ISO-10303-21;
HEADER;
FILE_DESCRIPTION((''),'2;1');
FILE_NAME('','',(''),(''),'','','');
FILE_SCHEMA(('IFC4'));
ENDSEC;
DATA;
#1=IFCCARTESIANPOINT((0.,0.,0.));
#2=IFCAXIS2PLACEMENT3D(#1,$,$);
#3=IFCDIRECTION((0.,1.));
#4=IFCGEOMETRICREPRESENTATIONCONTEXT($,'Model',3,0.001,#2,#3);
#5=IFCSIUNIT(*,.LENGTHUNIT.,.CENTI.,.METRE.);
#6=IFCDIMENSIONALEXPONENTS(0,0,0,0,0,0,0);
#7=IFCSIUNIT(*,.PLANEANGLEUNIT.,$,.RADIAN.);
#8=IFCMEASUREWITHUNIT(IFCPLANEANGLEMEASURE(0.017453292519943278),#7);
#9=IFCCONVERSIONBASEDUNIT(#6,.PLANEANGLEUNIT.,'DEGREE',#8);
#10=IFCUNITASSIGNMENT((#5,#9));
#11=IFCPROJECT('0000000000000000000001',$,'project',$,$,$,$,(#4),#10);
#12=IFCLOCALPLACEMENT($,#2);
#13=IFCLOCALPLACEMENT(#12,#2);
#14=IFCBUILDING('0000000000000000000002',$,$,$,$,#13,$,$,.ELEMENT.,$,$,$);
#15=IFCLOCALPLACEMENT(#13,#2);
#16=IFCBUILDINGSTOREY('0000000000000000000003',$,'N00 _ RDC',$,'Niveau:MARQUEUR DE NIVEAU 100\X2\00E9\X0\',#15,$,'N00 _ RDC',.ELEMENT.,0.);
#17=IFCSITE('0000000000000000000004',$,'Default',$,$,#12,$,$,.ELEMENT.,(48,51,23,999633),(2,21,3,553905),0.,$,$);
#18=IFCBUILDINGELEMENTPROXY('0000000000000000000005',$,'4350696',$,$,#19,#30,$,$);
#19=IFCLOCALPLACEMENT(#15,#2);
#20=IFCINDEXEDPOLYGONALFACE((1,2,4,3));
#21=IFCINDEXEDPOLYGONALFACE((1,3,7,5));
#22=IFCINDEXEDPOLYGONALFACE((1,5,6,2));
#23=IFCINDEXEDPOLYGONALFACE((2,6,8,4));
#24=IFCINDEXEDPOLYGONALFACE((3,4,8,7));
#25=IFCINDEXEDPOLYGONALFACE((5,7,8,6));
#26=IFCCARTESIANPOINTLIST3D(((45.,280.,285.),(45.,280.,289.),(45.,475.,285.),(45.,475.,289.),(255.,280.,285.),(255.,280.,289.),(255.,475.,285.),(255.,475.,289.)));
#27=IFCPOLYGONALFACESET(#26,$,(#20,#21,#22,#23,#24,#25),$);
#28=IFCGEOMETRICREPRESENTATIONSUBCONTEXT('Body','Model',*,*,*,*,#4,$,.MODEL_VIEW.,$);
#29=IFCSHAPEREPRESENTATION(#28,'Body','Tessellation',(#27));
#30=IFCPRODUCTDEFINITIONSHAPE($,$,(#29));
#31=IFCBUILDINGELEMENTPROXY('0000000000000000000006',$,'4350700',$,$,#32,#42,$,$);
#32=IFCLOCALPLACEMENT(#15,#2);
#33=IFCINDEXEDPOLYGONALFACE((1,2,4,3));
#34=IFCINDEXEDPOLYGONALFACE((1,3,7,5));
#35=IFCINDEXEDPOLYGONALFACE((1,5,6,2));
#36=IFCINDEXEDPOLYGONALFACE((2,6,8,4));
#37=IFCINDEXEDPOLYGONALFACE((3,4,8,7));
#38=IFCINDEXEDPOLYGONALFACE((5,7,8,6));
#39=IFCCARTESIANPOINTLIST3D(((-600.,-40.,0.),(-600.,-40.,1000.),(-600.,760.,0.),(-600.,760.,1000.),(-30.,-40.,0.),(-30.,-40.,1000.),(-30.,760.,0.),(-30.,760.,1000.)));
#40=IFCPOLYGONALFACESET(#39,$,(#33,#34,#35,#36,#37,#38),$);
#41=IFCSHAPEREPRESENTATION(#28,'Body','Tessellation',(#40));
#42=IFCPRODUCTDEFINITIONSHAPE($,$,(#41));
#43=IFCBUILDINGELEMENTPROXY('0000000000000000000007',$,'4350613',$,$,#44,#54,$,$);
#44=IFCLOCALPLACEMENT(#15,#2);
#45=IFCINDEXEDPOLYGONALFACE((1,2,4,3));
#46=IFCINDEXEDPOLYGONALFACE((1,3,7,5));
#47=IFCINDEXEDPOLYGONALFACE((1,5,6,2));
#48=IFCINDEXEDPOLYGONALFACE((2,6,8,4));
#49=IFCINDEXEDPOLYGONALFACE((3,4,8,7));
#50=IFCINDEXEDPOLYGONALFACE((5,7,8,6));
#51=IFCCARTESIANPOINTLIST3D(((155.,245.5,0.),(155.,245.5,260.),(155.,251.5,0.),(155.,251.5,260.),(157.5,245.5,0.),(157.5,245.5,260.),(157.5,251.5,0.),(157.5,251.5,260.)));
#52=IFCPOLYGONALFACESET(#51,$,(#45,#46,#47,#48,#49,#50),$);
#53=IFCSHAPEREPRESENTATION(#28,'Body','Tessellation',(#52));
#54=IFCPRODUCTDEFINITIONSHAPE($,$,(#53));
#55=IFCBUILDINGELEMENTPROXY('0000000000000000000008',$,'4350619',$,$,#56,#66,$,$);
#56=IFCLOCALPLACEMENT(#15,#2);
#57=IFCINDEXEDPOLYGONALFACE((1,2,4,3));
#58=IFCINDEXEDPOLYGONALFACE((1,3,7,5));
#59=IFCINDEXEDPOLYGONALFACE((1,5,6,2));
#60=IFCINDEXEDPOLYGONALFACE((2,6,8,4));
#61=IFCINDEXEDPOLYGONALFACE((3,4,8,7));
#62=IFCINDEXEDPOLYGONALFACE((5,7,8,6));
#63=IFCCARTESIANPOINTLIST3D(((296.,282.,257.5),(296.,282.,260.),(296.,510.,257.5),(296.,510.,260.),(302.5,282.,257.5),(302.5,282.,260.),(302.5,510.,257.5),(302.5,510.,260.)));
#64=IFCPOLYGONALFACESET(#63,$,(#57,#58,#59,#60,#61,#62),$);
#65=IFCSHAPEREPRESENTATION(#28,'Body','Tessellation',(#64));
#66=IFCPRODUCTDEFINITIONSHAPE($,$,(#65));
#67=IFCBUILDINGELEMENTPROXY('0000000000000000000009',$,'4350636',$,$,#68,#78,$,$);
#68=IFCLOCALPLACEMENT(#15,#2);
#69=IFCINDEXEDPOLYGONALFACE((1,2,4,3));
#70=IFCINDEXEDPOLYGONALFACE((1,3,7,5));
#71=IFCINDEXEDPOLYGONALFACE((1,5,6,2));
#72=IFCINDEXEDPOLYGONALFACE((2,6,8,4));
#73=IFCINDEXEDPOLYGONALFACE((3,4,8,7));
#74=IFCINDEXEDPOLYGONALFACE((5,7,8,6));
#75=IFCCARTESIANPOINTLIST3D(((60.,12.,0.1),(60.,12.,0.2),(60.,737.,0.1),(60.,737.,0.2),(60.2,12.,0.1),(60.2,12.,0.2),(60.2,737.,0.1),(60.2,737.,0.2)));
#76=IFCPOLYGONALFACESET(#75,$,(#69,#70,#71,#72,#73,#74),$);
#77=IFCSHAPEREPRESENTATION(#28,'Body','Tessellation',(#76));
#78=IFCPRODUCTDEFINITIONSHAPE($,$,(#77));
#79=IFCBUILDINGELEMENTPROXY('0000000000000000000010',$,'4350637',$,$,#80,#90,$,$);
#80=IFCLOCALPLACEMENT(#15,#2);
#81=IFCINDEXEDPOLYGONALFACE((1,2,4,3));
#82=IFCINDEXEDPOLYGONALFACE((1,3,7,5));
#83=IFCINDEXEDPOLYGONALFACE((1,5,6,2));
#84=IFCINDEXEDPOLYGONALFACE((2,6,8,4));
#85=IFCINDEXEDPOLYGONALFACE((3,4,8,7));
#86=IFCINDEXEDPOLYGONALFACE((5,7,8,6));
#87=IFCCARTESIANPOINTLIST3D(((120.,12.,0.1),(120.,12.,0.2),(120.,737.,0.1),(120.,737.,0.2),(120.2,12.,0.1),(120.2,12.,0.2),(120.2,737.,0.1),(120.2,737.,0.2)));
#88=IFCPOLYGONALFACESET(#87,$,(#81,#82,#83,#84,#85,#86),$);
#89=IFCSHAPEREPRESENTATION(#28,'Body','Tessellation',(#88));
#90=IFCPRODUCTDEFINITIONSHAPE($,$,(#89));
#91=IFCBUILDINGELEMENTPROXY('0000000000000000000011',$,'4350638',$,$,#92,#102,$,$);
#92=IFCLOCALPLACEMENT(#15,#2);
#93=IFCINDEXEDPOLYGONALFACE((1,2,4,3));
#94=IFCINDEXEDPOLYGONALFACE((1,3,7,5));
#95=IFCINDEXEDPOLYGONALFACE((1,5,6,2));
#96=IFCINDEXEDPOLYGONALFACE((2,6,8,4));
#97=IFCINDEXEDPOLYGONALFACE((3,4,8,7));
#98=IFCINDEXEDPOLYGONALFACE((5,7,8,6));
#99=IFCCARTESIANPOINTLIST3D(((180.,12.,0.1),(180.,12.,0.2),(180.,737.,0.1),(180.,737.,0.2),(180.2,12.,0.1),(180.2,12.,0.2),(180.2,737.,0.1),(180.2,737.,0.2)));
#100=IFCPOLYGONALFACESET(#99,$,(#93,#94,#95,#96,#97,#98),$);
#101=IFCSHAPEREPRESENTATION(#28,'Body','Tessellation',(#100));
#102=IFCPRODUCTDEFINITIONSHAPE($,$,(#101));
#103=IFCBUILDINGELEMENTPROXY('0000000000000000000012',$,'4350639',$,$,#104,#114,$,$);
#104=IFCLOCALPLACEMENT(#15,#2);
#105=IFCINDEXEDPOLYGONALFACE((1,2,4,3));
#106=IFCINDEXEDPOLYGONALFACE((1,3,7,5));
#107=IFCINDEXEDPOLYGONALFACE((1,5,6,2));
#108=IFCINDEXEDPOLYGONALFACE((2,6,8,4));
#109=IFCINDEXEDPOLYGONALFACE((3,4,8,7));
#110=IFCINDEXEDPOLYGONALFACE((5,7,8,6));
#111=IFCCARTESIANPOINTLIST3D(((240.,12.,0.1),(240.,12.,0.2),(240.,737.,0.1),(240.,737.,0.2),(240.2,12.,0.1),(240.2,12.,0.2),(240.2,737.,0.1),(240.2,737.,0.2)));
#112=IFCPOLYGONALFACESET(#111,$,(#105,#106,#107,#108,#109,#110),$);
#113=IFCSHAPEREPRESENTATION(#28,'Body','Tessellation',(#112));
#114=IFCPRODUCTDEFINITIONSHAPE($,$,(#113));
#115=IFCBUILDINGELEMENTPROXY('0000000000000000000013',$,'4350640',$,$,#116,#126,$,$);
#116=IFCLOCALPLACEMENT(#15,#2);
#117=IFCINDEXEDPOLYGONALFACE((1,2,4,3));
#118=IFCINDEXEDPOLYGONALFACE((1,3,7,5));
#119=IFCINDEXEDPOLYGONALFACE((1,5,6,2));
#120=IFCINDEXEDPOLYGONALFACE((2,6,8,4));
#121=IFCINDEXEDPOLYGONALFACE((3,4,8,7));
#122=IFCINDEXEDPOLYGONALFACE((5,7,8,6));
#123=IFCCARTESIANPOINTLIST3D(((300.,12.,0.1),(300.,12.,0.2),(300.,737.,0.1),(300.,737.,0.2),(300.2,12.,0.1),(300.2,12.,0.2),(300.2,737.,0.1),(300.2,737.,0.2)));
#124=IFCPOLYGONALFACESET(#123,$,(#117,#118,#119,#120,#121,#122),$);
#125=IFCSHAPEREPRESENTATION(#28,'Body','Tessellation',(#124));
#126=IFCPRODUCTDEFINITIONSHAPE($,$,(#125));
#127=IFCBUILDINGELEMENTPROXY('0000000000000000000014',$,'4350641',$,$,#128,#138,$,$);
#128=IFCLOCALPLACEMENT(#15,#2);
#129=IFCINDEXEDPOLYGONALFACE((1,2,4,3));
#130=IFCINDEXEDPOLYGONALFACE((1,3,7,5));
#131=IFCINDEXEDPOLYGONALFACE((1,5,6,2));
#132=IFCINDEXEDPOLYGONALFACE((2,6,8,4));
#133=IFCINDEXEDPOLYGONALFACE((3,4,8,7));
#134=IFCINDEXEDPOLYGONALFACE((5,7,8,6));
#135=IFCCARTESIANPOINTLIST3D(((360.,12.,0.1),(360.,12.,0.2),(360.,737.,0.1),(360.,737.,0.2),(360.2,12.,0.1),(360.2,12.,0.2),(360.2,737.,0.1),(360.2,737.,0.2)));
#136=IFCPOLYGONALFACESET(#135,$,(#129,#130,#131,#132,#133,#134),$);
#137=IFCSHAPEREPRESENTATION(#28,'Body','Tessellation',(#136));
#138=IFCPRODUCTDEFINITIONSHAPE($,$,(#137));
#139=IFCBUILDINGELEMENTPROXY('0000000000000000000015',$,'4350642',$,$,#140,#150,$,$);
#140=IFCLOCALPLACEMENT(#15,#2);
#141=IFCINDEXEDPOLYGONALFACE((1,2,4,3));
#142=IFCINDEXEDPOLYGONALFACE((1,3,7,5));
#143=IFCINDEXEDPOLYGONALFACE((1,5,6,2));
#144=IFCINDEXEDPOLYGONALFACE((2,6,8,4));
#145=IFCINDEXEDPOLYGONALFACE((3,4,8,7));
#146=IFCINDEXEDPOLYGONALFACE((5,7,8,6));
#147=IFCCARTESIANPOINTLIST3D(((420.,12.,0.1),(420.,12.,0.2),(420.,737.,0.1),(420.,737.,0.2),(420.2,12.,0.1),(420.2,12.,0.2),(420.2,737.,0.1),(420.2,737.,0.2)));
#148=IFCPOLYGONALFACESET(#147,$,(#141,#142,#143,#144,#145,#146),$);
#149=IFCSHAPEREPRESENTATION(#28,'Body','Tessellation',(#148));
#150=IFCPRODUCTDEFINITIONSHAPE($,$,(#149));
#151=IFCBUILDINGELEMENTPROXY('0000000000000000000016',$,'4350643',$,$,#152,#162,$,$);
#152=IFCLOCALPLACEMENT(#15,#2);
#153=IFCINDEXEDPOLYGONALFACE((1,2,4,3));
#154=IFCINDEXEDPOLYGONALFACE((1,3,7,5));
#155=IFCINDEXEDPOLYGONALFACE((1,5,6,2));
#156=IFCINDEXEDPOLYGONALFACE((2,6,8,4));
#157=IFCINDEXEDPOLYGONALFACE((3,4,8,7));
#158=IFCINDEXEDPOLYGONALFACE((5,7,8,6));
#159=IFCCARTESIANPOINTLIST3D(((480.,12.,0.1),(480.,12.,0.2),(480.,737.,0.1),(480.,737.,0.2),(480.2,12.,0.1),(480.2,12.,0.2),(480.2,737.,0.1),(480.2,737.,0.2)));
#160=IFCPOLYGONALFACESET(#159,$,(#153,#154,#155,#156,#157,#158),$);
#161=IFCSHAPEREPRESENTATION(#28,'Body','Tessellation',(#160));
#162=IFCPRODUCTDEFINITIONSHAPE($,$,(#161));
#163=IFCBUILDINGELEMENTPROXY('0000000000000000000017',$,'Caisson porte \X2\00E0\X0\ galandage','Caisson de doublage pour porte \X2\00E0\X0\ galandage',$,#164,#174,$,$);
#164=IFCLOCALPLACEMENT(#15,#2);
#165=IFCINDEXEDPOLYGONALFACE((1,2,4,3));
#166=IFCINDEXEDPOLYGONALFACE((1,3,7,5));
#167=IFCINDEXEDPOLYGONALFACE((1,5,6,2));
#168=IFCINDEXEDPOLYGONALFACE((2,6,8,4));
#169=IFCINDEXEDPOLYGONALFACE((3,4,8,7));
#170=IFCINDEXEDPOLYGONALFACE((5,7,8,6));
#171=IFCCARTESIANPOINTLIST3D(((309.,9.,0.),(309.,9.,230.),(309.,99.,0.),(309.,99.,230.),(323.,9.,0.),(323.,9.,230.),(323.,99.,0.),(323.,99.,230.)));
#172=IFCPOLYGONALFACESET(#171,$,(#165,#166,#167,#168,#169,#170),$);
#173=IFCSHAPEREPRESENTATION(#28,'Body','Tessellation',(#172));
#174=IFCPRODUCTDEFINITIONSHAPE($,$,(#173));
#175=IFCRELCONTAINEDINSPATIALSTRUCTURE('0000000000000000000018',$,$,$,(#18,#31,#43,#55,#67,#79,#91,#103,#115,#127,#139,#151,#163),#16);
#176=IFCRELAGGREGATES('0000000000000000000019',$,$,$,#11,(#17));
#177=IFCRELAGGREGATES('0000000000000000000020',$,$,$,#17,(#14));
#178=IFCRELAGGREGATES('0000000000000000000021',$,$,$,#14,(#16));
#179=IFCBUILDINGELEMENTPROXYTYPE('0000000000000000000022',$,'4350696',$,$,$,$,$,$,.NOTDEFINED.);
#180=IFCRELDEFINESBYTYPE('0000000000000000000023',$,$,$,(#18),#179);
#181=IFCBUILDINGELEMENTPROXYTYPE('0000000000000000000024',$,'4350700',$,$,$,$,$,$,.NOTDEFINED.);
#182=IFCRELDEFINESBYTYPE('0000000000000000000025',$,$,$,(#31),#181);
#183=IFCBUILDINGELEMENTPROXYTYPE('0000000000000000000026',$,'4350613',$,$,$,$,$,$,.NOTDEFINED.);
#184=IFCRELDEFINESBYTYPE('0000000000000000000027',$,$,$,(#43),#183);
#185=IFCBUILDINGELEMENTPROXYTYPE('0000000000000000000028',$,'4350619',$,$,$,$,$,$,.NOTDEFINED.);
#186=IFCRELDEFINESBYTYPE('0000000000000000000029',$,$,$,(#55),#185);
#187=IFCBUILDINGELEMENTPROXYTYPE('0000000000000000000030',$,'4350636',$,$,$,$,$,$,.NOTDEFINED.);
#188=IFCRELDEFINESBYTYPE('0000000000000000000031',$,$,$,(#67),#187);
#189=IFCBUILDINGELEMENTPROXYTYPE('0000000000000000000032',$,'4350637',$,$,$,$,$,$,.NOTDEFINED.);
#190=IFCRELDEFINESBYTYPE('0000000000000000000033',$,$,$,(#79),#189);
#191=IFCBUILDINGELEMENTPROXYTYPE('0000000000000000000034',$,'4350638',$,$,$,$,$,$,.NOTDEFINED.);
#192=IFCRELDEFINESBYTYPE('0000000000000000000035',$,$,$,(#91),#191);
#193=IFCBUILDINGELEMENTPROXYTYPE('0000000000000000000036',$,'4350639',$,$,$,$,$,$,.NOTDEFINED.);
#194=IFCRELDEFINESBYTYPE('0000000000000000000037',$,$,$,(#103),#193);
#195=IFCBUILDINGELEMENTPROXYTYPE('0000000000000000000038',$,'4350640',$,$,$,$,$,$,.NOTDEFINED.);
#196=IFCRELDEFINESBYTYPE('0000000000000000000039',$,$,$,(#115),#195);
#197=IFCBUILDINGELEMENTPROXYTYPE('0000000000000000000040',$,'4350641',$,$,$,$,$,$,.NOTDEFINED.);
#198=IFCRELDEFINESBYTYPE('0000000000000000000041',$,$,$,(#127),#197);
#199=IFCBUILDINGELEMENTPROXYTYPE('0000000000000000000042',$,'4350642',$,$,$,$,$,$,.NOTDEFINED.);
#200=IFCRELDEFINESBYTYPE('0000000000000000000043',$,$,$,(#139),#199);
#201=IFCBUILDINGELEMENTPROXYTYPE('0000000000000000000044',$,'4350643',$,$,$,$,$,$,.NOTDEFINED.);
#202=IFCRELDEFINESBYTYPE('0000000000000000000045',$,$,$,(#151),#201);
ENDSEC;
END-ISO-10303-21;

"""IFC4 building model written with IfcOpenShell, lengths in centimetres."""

from ifc_helpers import new_model, entity, si_unit, converted_unit, direction, frame, frame_2d, origin, origin_with_axes, origin_2d_with_axis, place, context, subcontext, project, spatial, rectangle, extrude, type_object, element, save


model = new_model("IFC4")

# Units and contexts
model_context = context("Model", 3, precision=0.001, world=origin(), true_north=direction((0.0, 1.0)))
body_context = subcontext(model_context, "Body", "Model", "MODEL_VIEW")
ifc_project = project(units=[si_unit("LENGTHUNIT", "METRE", prefix="CENTI"), converted_unit("PLANEANGLEUNIT", "DEGREE", entity("IfcPlaneAngleMeasure", 0.017453292519943278), si_unit("PLANEANGLEUNIT", "RADIAN"), dimensions=[0, 0, 0, 0, 0, 0, 0])], contexts=[model_context])

# Site, building, storey
site_placement = place(None, origin())
site = spatial("IfcSite", under=ifc_project, at=site_placement, Name="Default", CompositionType="ELEMENT", RefLatitude=(48, 51, 23, 999633), RefLongitude=(2, 21, 3, 553905), RefElevation=0.0)
building_placement = place(site_placement, origin())
building = spatial("IfcBuilding", under=site, at=building_placement, CompositionType="ELEMENT")
storey_placement = place(building_placement, origin())
storey = spatial("IfcBuildingStorey", under=building, at=storey_placement, Name="N00 _ RDC", ObjectType="Niveau:MARQUEUR DE NIVEAU 100é", LongName="N00 _ RDC", CompositionType="ELEMENT", Elevation=0.0)

# Building element proxies
building_element_proxy_type_1 = type_object("IfcBuildingElementProxyType", Name="4350696", PredefinedType="NOTDEFINED")
proxy_1_placement = place(storey_placement, origin())
element("IfcBuildingElementProxy", 1, at=proxy_1_placement, inside=storey, type_object=building_element_proxy_type_1, Name="4350696", context=body_context, shape_type="SweptSolid", body=[
    extrude(rectangle(XDim=210.0, YDim=195.0, at=frame_2d((0.0, 0.0), x_axis=(1.0, 0.0))), frame((150.0, 377.5, 285.0)), (0.0, 0.0, 1.0), 4.0),
])
building_element_proxy_type_2 = type_object("IfcBuildingElementProxyType", Name="4350700", PredefinedType="NOTDEFINED")
proxy_2_placement = place(storey_placement, origin())
element("IfcBuildingElementProxy", 2, at=proxy_2_placement, inside=storey, type_object=building_element_proxy_type_2, Name="4350700", context=body_context, shape_type="SweptSolid", body=[
    extrude(rectangle(XDim=570.0, YDim=800.0, at=origin_2d_with_axis()), frame((-315.0, 360.0, 0.0)), (0.0, 0.0, 1.0), 1000.0),
])
building_element_proxy_type_3 = type_object("IfcBuildingElementProxyType", Name="4350613", PredefinedType="NOTDEFINED")
proxy_3_placement = place(storey_placement, origin())
element("IfcBuildingElementProxy", 3, at=proxy_3_placement, inside=storey, type_object=building_element_proxy_type_3, Name="4350613", context=body_context, shape_type="SweptSolid", body=[
    extrude(rectangle(XDim=2.5, YDim=6.0, at=frame_2d((0.0, 0.0), x_axis=(1.0, 0.0))), frame((156.25, 248.5, 0.0)), (0.0, 0.0, 1.0), 260.0),
])
building_element_proxy_type_4 = type_object("IfcBuildingElementProxyType", Name="4350619", PredefinedType="NOTDEFINED")
proxy_4_placement = place(storey_placement, origin())
element("IfcBuildingElementProxy", 4, at=proxy_4_placement, inside=storey, type_object=building_element_proxy_type_4, Name="4350619", context=body_context, shape_type="SweptSolid", body=[
    extrude(rectangle(XDim=6.5, YDim=228.0, at=frame_2d((0.0, 0.0), x_axis=(1.0, 0.0))), frame((299.25, 396.0, 257.5)), (0.0, 0.0, 1.0), 2.5),
])
building_element_proxy_type_5 = type_object("IfcBuildingElementProxyType", Name="4350636", PredefinedType="NOTDEFINED")
proxy_5_placement = place(storey_placement, origin())
element("IfcBuildingElementProxy", 5, at=proxy_5_placement, inside=storey, type_object=building_element_proxy_type_5, Name="4350636", context=body_context, shape_type="SweptSolid", body=[
    extrude(rectangle(XDim=0.2, YDim=725.0, at=frame_2d((0.0, 0.0), x_axis=(1.0, 0.0))), frame((60.1, 374.5, 0.1)), (0.0, 0.0, 1.0), 0.1),
])
building_element_proxy_type_6 = type_object("IfcBuildingElementProxyType", Name="4350637", PredefinedType="NOTDEFINED")
proxy_6_placement = place(storey_placement, origin())
element("IfcBuildingElementProxy", 6, at=proxy_6_placement, inside=storey, type_object=building_element_proxy_type_6, Name="4350637", context=body_context, shape_type="SweptSolid", body=[
    extrude(rectangle(XDim=0.2, YDim=725.0, at=frame_2d((0.0, 0.0), x_axis=(1.0, 0.0))), frame((120.1, 374.5, 0.1)), (0.0, 0.0, 1.0), 0.1),
])
building_element_proxy_type_7 = type_object("IfcBuildingElementProxyType", Name="4350638", PredefinedType="NOTDEFINED")
proxy_7_placement = place(storey_placement, origin())
element("IfcBuildingElementProxy", 7, at=proxy_7_placement, inside=storey, type_object=building_element_proxy_type_7, Name="4350638", context=body_context, shape_type="SweptSolid", body=[
    extrude(rectangle(XDim=0.2, YDim=725.0, at=origin_2d_with_axis()), frame((180.1, 374.5, 0.1)), (0.0, 0.0, 1.0), 0.1),
])
building_element_proxy_type_8 = type_object("IfcBuildingElementProxyType", Name="4350639", PredefinedType="NOTDEFINED")
proxy_8_placement = place(storey_placement, origin())
element("IfcBuildingElementProxy", 8, at=proxy_8_placement, inside=storey, type_object=building_element_proxy_type_8, Name="4350639", context=body_context, shape_type="SweptSolid", body=[
    extrude(rectangle(XDim=0.2, YDim=725.0, at=frame_2d((0.0, 0.0), x_axis=(1.0, 0.0))), frame((240.1, 374.5, 0.1)), (0.0, 0.0, 1.0), 0.1),
])
building_element_proxy_type_9 = type_object("IfcBuildingElementProxyType", Name="4350640", PredefinedType="NOTDEFINED")
proxy_9_placement = place(storey_placement, origin())
element("IfcBuildingElementProxy", 9, at=proxy_9_placement, inside=storey, type_object=building_element_proxy_type_9, Name="4350640", context=body_context, shape_type="SweptSolid", body=[
    extrude(rectangle(XDim=0.2, YDim=725.0, at=origin_2d_with_axis()), frame((300.1, 374.5, 0.1)), (0.0, 0.0, 1.0), 0.1),
])
building_element_proxy_type_10 = type_object("IfcBuildingElementProxyType", Name="4350641", PredefinedType="NOTDEFINED")
proxy_10_placement = place(storey_placement, origin())
element("IfcBuildingElementProxy", 10, at=proxy_10_placement, inside=storey, type_object=building_element_proxy_type_10, Name="4350641", context=body_context, shape_type="SweptSolid", body=[
    extrude(rectangle(XDim=0.2, YDim=725.0, at=origin_2d_with_axis()), frame((360.1, 374.5, 0.1)), (0.0, 0.0, 1.0), 0.1),
])
building_element_proxy_type_11 = type_object("IfcBuildingElementProxyType", Name="4350642", PredefinedType="NOTDEFINED")
proxy_11_placement = place(storey_placement, origin())
element("IfcBuildingElementProxy", 11, at=proxy_11_placement, inside=storey, type_object=building_element_proxy_type_11, Name="4350642", context=body_context, shape_type="SweptSolid", body=[
    extrude(rectangle(XDim=0.2, YDim=725.0, at=origin_2d_with_axis()), frame((420.1, 374.5, 0.1)), (0.0, 0.0, 1.0), 0.1),
])
building_element_proxy_type_12 = type_object("IfcBuildingElementProxyType", Name="4350643", PredefinedType="NOTDEFINED")
proxy_12_placement = place(storey_placement, origin())
element("IfcBuildingElementProxy", 12, at=proxy_12_placement, inside=storey, type_object=building_element_proxy_type_12, Name="4350643", context=body_context, shape_type="SweptSolid", body=[
    extrude(rectangle(XDim=0.2, YDim=725.0, at=origin_2d_with_axis()), frame((480.1, 374.5, 0.1)), (0.0, 0.0, 1.0), 0.1),
])
proxy_13_placement = place(storey_placement, origin_with_axes())
element("IfcBuildingElementProxy", 13, at=proxy_13_placement, inside=storey, Name="Caisson porte à galandage", Description="Caisson de doublage pour porte à galandage", context=body_context, shape_type="SweptSolid", body=[
    extrude(rectangle(XDim=14.0, YDim=90.0, at=frame_2d((316.0, 54.0))), origin(), (0.0, 0.0, 1.0), 230.0),
])

save(model, "model.ifc")
